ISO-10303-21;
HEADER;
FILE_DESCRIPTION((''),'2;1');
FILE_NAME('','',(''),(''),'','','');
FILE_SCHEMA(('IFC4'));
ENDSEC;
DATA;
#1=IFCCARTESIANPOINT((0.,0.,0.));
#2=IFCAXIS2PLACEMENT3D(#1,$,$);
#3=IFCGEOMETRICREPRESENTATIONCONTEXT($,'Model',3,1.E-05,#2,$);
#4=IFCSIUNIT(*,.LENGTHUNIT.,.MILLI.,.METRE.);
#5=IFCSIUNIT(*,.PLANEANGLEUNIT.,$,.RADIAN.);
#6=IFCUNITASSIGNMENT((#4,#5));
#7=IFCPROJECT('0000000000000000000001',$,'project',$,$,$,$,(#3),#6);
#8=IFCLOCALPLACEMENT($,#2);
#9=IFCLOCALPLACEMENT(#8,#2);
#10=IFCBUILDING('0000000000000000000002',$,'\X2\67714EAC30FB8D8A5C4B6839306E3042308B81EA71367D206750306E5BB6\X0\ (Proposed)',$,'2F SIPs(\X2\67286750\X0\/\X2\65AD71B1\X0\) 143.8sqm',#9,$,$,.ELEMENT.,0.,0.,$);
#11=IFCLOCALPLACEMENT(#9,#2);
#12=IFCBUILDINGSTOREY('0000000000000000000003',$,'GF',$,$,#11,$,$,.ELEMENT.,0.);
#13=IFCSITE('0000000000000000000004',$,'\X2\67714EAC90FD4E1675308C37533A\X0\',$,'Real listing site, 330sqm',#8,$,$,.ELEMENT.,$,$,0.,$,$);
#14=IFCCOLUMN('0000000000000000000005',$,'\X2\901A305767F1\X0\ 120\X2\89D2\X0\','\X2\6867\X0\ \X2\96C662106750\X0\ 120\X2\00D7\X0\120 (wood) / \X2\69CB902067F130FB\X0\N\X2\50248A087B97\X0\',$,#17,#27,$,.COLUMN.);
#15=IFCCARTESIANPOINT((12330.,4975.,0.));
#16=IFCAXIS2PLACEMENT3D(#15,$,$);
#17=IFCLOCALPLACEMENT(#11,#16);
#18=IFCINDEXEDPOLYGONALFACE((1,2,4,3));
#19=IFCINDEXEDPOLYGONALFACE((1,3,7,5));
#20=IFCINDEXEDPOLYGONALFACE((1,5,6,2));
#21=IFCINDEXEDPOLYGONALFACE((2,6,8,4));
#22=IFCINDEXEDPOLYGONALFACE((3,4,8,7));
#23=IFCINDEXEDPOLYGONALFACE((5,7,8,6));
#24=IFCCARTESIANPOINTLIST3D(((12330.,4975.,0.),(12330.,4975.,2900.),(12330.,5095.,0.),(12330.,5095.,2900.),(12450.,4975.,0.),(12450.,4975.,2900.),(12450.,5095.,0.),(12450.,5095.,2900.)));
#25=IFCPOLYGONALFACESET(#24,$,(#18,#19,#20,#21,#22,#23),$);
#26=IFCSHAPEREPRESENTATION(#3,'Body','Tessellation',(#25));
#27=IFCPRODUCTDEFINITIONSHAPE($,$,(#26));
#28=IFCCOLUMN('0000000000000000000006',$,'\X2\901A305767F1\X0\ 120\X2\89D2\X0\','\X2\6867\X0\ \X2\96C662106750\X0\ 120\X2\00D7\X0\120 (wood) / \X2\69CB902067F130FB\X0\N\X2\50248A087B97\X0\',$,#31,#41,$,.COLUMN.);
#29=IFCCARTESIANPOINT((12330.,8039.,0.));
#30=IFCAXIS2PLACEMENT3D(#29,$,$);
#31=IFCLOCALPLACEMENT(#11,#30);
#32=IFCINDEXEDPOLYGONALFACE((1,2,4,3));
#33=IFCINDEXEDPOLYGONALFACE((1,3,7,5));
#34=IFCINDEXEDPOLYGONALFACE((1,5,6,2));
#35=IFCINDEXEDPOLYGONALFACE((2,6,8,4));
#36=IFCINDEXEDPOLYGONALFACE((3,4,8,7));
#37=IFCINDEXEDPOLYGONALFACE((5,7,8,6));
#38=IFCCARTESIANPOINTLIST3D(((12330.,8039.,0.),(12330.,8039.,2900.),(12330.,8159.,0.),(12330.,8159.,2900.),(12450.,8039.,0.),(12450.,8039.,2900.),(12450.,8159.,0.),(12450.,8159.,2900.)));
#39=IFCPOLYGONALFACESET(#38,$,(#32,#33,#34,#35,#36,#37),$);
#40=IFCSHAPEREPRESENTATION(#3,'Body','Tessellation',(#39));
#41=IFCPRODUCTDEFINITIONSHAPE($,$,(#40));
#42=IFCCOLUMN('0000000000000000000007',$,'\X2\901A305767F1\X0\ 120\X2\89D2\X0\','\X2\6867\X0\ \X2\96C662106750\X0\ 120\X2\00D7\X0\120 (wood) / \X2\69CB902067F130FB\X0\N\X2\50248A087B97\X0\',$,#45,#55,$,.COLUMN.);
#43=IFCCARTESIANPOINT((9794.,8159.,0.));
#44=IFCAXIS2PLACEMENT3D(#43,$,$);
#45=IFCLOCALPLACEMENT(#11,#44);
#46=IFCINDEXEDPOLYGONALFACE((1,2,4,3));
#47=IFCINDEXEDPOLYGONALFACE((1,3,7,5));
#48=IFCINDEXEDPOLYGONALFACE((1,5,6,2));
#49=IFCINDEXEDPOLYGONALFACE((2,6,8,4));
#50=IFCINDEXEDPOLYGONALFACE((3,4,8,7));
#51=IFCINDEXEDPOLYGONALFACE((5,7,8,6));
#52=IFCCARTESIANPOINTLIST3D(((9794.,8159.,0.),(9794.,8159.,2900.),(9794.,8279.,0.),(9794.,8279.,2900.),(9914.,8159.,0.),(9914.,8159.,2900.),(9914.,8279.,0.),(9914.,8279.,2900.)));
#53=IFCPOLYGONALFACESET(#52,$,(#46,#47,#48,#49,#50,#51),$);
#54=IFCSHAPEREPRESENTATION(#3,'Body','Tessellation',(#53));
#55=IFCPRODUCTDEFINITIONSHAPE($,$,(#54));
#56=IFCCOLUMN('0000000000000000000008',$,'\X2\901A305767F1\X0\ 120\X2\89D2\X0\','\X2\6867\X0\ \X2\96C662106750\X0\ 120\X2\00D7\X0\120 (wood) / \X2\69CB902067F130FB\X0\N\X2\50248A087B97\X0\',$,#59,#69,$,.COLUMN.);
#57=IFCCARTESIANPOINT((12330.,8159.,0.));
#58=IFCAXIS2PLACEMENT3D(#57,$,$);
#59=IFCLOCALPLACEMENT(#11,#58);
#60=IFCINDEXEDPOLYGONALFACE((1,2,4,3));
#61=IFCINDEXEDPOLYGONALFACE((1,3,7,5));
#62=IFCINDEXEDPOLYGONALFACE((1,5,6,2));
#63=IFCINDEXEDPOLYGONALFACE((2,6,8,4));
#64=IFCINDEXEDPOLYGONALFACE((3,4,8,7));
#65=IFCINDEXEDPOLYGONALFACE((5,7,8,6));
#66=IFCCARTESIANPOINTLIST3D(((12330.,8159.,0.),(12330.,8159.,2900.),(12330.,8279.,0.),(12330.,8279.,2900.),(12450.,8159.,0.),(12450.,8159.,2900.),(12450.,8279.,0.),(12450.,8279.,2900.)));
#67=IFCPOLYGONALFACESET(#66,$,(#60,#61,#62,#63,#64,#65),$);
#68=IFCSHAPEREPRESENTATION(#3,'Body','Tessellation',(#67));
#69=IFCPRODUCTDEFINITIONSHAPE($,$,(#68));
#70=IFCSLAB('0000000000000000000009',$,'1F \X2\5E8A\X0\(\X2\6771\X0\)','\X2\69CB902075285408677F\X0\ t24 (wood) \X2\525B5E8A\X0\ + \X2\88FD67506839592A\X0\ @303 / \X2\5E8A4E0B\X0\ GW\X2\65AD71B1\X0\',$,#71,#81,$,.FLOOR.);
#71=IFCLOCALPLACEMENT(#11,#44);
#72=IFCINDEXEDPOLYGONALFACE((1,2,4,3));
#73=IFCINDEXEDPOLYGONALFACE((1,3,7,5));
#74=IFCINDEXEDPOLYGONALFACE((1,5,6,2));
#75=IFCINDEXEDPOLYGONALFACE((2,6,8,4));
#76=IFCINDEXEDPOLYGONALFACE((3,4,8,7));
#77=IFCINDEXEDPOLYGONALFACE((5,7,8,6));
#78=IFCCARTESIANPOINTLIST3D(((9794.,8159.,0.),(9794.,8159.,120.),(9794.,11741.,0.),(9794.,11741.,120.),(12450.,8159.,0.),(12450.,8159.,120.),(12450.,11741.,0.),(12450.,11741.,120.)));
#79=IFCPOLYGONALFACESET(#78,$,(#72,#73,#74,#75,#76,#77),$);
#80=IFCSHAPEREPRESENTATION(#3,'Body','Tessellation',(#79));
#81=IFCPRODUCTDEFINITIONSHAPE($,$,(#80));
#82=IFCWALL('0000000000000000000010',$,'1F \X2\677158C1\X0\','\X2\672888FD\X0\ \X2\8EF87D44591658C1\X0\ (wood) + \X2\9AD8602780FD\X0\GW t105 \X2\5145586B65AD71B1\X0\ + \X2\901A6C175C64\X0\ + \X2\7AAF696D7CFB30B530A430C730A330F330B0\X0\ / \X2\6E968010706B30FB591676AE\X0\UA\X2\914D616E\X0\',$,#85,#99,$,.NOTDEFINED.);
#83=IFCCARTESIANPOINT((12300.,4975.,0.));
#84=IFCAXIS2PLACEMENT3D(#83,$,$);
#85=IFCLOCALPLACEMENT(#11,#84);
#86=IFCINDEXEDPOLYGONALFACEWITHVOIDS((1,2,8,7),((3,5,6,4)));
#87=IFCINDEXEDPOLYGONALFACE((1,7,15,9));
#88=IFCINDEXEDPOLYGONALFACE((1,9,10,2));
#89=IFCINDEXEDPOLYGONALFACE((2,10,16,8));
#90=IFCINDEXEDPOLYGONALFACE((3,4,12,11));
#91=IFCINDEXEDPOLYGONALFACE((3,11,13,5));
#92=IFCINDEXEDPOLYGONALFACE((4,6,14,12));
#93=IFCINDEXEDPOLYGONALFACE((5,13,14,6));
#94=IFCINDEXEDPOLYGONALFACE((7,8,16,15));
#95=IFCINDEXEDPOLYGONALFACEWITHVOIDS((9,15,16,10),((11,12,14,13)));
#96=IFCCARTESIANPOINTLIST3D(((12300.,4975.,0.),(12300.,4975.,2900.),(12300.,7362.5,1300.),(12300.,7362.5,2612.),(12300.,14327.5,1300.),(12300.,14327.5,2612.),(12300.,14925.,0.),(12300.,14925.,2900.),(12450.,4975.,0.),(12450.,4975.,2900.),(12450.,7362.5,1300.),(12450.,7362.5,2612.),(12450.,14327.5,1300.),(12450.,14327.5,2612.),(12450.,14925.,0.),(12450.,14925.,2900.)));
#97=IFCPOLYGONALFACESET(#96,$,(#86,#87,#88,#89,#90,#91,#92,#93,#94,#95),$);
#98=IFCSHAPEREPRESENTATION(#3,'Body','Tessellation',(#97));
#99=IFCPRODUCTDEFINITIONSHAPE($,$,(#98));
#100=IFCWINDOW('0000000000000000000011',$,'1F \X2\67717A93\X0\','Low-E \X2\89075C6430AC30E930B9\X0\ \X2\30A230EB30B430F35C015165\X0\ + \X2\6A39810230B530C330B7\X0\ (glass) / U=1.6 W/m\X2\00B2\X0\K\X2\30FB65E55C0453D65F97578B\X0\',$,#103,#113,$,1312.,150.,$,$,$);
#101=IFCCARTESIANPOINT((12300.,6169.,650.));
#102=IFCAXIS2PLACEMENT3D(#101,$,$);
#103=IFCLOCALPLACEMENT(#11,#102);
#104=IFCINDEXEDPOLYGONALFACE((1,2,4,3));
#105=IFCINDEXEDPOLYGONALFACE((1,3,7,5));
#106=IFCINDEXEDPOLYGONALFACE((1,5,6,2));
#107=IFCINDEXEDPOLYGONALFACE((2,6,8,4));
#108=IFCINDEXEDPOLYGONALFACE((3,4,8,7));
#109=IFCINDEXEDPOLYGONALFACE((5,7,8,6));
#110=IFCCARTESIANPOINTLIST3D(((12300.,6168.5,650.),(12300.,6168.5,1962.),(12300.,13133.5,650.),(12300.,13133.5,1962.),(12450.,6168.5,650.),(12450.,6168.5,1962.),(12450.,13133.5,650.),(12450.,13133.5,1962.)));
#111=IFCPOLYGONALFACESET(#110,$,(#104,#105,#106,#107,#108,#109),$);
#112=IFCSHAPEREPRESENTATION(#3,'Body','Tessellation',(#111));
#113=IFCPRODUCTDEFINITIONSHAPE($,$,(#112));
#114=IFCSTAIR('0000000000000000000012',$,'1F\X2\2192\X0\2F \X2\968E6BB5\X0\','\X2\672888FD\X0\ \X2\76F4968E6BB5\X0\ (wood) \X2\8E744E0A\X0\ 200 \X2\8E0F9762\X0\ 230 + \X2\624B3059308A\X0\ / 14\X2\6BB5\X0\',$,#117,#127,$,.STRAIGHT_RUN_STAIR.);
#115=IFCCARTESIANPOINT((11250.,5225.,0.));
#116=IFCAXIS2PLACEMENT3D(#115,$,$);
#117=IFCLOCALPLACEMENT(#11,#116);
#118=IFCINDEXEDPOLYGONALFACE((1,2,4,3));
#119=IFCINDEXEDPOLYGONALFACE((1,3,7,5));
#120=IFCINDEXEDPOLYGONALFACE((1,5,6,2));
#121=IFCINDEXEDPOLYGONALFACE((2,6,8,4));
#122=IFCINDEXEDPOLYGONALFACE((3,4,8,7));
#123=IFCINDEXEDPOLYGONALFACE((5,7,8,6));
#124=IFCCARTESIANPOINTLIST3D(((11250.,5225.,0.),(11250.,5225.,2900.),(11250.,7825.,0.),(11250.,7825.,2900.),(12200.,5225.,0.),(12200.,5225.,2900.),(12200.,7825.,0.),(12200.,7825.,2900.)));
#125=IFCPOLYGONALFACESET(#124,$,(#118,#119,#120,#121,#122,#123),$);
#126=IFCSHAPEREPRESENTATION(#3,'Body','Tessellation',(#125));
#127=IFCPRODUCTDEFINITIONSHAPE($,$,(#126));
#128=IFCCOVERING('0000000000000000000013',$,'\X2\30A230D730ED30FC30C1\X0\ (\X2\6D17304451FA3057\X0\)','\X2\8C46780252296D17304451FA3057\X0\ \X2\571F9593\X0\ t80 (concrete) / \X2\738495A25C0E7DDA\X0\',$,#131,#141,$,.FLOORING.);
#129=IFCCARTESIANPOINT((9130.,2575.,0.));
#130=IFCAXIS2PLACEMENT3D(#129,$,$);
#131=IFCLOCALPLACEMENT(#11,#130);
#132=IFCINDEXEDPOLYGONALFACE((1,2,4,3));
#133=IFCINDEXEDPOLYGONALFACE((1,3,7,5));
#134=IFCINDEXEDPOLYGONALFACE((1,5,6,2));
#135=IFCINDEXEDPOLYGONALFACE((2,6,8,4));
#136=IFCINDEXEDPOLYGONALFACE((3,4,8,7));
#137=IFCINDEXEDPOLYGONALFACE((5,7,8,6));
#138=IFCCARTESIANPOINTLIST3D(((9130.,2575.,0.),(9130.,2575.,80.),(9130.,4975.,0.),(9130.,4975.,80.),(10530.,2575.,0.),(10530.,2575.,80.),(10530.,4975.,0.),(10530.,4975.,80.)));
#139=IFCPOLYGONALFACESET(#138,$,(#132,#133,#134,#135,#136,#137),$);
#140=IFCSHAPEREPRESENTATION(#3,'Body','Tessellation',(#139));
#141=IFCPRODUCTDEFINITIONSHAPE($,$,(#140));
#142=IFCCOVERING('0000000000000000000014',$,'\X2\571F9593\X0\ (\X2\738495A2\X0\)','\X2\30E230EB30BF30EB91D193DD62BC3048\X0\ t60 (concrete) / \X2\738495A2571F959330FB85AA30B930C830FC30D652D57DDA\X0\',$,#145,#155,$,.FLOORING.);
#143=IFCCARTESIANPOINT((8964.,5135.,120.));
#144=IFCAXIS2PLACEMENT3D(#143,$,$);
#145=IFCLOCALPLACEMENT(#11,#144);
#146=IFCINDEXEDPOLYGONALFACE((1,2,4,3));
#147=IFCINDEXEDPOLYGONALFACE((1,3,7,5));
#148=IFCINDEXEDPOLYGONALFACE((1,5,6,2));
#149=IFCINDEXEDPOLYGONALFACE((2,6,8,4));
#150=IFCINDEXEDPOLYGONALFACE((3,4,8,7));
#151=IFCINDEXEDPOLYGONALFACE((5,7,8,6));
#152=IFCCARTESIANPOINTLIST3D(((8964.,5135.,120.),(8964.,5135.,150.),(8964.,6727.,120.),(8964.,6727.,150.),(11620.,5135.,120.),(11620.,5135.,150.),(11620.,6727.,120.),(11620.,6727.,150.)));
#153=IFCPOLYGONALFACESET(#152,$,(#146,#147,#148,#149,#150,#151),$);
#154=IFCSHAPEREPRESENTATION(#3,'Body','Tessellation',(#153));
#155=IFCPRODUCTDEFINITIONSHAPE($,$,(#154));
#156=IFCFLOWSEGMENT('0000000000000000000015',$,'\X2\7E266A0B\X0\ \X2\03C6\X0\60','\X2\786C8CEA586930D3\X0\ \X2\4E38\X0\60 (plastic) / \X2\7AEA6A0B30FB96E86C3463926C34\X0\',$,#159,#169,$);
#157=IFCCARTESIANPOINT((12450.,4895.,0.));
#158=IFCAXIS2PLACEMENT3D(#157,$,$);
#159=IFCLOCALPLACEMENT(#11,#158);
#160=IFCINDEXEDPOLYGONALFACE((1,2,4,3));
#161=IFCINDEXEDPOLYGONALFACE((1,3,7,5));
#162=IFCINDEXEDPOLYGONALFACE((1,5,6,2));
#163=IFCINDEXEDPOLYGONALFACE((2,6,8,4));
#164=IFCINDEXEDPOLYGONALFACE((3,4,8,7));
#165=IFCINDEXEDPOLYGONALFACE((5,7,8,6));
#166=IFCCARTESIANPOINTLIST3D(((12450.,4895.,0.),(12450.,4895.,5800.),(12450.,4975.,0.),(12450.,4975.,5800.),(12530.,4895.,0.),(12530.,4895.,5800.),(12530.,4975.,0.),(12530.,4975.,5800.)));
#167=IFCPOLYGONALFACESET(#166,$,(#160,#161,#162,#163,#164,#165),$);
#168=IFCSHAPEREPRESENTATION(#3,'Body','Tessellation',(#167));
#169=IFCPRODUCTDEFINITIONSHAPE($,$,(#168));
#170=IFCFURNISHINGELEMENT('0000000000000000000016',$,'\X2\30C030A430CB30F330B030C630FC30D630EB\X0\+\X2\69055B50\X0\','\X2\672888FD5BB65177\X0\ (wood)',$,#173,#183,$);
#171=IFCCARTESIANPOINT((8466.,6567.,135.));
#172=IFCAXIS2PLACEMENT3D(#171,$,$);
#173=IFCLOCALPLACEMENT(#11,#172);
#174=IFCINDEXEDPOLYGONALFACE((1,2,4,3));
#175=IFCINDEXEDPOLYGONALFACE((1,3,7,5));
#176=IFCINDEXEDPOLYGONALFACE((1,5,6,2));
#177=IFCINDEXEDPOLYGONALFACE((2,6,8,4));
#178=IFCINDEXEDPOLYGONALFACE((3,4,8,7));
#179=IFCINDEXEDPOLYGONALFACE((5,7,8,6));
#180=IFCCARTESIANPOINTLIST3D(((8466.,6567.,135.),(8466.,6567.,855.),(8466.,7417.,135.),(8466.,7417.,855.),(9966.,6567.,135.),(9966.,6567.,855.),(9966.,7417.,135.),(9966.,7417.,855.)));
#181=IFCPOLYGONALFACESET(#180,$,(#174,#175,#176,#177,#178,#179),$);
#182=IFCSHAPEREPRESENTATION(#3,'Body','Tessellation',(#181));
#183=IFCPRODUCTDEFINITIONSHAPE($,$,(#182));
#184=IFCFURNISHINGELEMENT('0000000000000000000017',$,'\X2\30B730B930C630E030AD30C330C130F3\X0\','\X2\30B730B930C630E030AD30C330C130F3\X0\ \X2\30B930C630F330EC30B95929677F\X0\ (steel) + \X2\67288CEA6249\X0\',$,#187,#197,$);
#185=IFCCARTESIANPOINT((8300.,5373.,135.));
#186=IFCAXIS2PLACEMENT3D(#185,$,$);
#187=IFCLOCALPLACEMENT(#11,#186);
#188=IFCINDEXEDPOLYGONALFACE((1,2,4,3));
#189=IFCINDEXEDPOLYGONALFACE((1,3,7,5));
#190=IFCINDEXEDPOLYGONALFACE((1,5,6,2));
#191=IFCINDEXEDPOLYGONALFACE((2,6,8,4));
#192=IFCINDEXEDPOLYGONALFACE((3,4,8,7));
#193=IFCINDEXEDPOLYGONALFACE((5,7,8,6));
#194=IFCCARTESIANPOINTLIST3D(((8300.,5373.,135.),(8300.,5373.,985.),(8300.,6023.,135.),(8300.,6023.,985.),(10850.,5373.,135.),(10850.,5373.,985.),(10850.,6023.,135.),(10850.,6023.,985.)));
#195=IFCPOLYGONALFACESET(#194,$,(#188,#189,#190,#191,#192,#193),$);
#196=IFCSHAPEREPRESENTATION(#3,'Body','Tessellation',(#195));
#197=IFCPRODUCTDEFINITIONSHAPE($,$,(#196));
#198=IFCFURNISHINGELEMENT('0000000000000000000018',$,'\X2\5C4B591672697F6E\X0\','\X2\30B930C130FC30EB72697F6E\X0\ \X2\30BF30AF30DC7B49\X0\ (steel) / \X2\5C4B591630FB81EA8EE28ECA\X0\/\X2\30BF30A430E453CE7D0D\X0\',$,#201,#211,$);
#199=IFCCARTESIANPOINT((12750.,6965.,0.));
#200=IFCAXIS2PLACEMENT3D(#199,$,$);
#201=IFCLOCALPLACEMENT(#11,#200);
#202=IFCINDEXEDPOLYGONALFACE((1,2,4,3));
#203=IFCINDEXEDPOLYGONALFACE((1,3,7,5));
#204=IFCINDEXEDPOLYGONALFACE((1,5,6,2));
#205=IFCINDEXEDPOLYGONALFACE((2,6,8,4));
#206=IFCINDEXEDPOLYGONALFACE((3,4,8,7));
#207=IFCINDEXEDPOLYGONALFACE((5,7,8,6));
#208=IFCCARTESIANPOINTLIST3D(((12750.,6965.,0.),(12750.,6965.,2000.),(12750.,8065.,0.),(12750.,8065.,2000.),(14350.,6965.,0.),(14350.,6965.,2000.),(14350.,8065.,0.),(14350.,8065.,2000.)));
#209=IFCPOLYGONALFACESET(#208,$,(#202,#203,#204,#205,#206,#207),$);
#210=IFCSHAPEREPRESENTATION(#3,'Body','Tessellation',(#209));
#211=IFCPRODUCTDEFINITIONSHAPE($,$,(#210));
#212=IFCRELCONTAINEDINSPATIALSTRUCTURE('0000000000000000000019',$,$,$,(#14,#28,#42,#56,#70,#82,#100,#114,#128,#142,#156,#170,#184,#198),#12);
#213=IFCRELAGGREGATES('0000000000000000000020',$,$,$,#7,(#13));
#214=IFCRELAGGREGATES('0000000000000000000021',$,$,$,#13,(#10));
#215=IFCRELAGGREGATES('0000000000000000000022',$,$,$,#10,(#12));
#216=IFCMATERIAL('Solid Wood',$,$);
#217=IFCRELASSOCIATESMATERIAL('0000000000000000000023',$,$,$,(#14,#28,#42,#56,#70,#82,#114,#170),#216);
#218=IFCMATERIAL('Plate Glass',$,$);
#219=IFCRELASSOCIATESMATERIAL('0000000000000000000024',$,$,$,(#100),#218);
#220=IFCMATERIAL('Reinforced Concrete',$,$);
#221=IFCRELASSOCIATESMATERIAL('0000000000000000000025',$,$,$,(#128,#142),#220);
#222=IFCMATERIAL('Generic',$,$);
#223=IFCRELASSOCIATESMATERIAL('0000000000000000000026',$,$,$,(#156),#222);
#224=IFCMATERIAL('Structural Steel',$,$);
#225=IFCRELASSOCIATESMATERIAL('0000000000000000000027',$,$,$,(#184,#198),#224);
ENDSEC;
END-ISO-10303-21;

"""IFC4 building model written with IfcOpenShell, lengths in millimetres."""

from ifc_helpers import new_model, si_unit, frame, frame_2d, origin, place, context, project, spatial, rectangle, extrude, material, element, fill, save


model = new_model("IFC4")

# Units and contexts
model_context = context("Model", 3, precision=1e-05, world=origin())
ifc_project = project(units=[si_unit("LENGTHUNIT", "METRE", prefix="MILLI"), si_unit("PLANEANGLEUNIT", "RADIAN")], contexts=[model_context])

# Site, building, storey
site_placement = place(None, origin())
site = spatial("IfcSite", under=ifc_project, at=site_placement, Name="東京都世田谷区", ObjectType="Real listing site, 330sqm", CompositionType="ELEMENT", RefElevation=0.0)
building_placement = place(site_placement, origin())
building = spatial("IfcBuilding", under=site, at=building_placement, Name="東京・越屋根のある自然素材の家 (Proposed)", ObjectType="2F SIPs(木材/断熱) 143.8sqm", CompositionType="ELEMENT", ElevationOfRefHeight=0.0, ElevationOfTerrain=0.0)
storey_placement = place(building_placement, origin())
storey = spatial("IfcBuildingStorey", under=building, at=storey_placement, Name="GF", CompositionType="ELEMENT", Elevation=0.0)

# Columns
ifc_material_1 = material(Name="Solid Wood")
column_1_placement = place(storey_placement, frame((12330.0, 4975.0, 0.0)))
element("IfcColumn", 1, at=column_1_placement, inside=storey, material=ifc_material_1, Name="通し柱 120角", Description="桧 集成材 120×120 (wood) / 構造柱・N値計算", PredefinedType="COLUMN", context=model_context, shape_type="SweptSolid", body=[
    extrude(rectangle(XDim=120.0, YDim=120.0, at=frame_2d((60.0, 60.0))), frame((12330.0, 4975.0, 0.0)), (0.0, 0.0, 1.0), 2900.0),
])
column_2_placement = place(storey_placement, frame((12330.0, 8039.0, 0.0)))
element("IfcColumn", 2, at=column_2_placement, inside=storey, material=ifc_material_1, Name="通し柱 120角", Description="桧 集成材 120×120 (wood) / 構造柱・N値計算", PredefinedType="COLUMN", context=model_context, shape_type="SweptSolid", body=[
    extrude(rectangle(XDim=120.0, YDim=120.0, at=frame_2d((60.0, 60.0))), frame((12330.0, 8039.0, 0.0)), (0.0, 0.0, 1.0), 2900.0),
])
column_3_placement = place(storey_placement, frame((9794.0, 8159.0, 0.0)))
element("IfcColumn", 3, at=column_3_placement, inside=storey, material=ifc_material_1, Name="通し柱 120角", Description="桧 集成材 120×120 (wood) / 構造柱・N値計算", PredefinedType="COLUMN", context=model_context, shape_type="SweptSolid", body=[
    extrude(rectangle(XDim=120.0, YDim=120.0, at=frame_2d((60.0, 60.0))), frame((9794.0, 8159.0, 0.0)), (0.0, 0.0, 1.0), 2900.0),
])
column_4_placement = place(storey_placement, frame((12330.0, 8159.0, 0.0)))
element("IfcColumn", 4, at=column_4_placement, inside=storey, material=ifc_material_1, Name="通し柱 120角", Description="桧 集成材 120×120 (wood) / 構造柱・N値計算", PredefinedType="COLUMN", context=model_context, shape_type="SweptSolid", body=[
    extrude(rectangle(XDim=120.0, YDim=120.0, at=frame_2d((60.0, 60.0))), frame((12330.0, 8159.0, 0.0)), (0.0, 0.0, 1.0), 2900.0),
])

# Slab
slab_placement = place(storey_placement, frame((9794.0, 8159.0, 0.0)))
element("IfcSlab", 5, at=slab_placement, inside=storey, material=ifc_material_1, Name="1F 床(東)", Description="構造用合板 t24 (wood) 剛床 + 製材根太 @303 / 床下 GW断熱", PredefinedType="FLOOR", context=model_context, shape_type="SweptSolid", body=[
    extrude(rectangle(XDim=2656.0, YDim=3582.0, at=frame_2d((1328.0, 1791.0))), frame((9794.0, 8159.0, 0.0)), (0.0, 0.0, 1.0), 120.0),
])

# Wall, opening, window
wall_1_placement = place(storey_placement, frame((12300.0, 4975.0, 0.0)))
wall_1 = element("IfcWall", 6, at=wall_1_placement, inside=storey, material=ifc_material_1, Name="1F 東壁", Description="木製 軸組外壁 (wood) + 高性能GW t105 充填断熱 + 通気層 + 窯業系サイディング / 準耐火・外皮UA配慮", PredefinedType="NOTDEFINED", context=model_context, shape_type="SweptSolid", body=[
    extrude(rectangle(XDim=150.0, YDim=9950.0, at=frame_2d((75.0, 4975.0))), frame((12300.0, 4975.0, 0.0)), (0.0, 0.0, 1.0), 2900.0),
])
opening_placement = place(storey_placement, frame((12300.0, 6169.0, 650.0)))
opening = element("IfcOpeningElement", 7, at=opening_placement, cuts=wall_1, PredefinedType="NOTDEFINED", context=model_context, shape_type="SweptSolid", body=[
    extrude(rectangle(XDim=150.0, YDim=6965.0, at=frame_2d((75.0, 3482.0))), frame((12300.0, 6169.0, 650.0)), (0.0, 0.0, 1.0), 1312.0),
])
ifc_material_2 = material(Name="Plate Glass")
window_placement = place(storey_placement, frame((12300.0, 6169.0, 650.0)))
window = element("IfcWindow", 8, at=window_placement, inside=storey, material=ifc_material_2, Name="1F 東窓", Description="Low-E 複層ガラス アルゴン封入 + 樹脂サッシ (glass) / U=1.6 W/m²K・日射取得型", OverallHeight=1312.0, OverallWidth=150.0, context=model_context, shape_type="SweptSolid", body=[
    extrude(rectangle(XDim=150.0, YDim=6965.0, at=frame_2d((75.0, 3482.0))), frame((12300.0, 6169.0, 650.0)), (0.0, 0.0, 1.0), 1312.0),
])
fill(opening, window)

# Stair
stair_placement = place(storey_placement, frame((11250.0, 5225.0, 0.0)))
element("IfcStair", 9, at=stair_placement, inside=storey, material=ifc_material_1, Name="1F→2F 階段", Description="木製 直階段 (wood) 蹴上 200 踏面 230 + 手すり / 14段", PredefinedType="STRAIGHT_RUN_STAIR", context=model_context, shape_type="SweptSolid", body=[
    extrude(rectangle(XDim=950.0, YDim=2600.0, at=frame_2d((475.0, 1300.0))), frame((11250.0, 5225.0, 0.0)), (0.0, 0.0, 1.0), 2900.0),
])

# Coverings
ifc_material_3 = material(Name="Reinforced Concrete")
covering_1_placement = place(storey_placement, frame((9130.0, 2575.0, 0.0)))
element("IfcCovering", 10, at=covering_1_placement, inside=storey, material=ifc_material_3, Name="アプローチ (洗い出し)", Description="豆砂利洗い出し 土間 t80 (concrete) / 玄関導線", PredefinedType="FLOORING", context=model_context, shape_type="SweptSolid", body=[
    extrude(rectangle(XDim=1400.0, YDim=2400.0, at=frame_2d((700.0, 1200.0))), frame((9130.0, 2575.0, 0.0)), (0.0, 0.0, 1.0), 80.0),
])
covering_2_placement = place(storey_placement, frame((8964.0, 5135.0, 120.0)))
element("IfcCovering", 11, at=covering_2_placement, inside=storey, material=ifc_material_3, Name="土間 (玄関)", Description="モルタル金鏝押え t60 (concrete) / 玄関土間・薪ストーブ動線", PredefinedType="FLOORING", context=model_context, shape_type="SweptSolid", body=[
    extrude(rectangle(XDim=2656.0, YDim=1592.0, at=frame_2d((1328.0, 796.0))), frame((8964.0, 5135.0, 120.0)), (0.0, 0.0, 1.0), 30.0),
])

# Flow segment
ifc_material_4 = material(Name="Generic")
flow_segment_placement = place(storey_placement, frame((12450.0, 4895.0, 0.0)))
element("IfcFlowSegment", 12, at=flow_segment_placement, inside=storey, material=ifc_material_4, Name="縦樋 φ60", Description="硬質塩ビ 丸60 (plastic) / 竪樋・雨水排水", context=model_context, shape_type="SweptSolid", body=[
    extrude(rectangle(XDim=80.0, YDim=80.0, at=frame_2d((40.0, 40.0))), frame((12450.0, 4895.0, 0.0)), (0.0, 0.0, 1.0), 5800.0),
])

# Furnishing elements
furnishing_1_placement = place(storey_placement, frame((8466.0, 6567.0, 135.0)))
element("IfcFurnishingElement", 13, at=furnishing_1_placement, inside=storey, material=ifc_material_1, Name="ダイニングテーブル+椅子", Description="木製家具 (wood)", context=model_context, shape_type="SweptSolid", body=[
    extrude(rectangle(XDim=1500.0, YDim=850.0, at=frame_2d((750.0, 425.0))), frame((8466.0, 6567.0, 135.0)), (0.0, 0.0, 1.0), 720.0),
])
ifc_material_5 = material(Name="Structural Steel")
furnishing_2_placement = place(storey_placement, frame((8300.0, 5373.0, 135.0)))
element("IfcFurnishingElement", 14, at=furnishing_2_placement, inside=storey, material=ifc_material_5, Name="システムキッチン", Description="システムキッチン ステンレス天板 (steel) + 木質扉", context=model_context, shape_type="SweptSolid", body=[
    extrude(rectangle(XDim=2550.0, YDim=650.0, at=frame_2d((1275.0, 325.0))), frame((8300.0, 5373.0, 135.0)), (0.0, 0.0, 1.0), 850.0),
])
furnishing_3_placement = place(storey_placement, frame((12750.0, 6965.0, 0.0)))
element("IfcFurnishingElement", 15, at=furnishing_3_placement, inside=storey, material=ifc_material_5, Name="屋外物置", Description="スチール物置 タクボ等 (steel) / 屋外・自転車/タイヤ収納", context=model_context, shape_type="SweptSolid", body=[
    extrude(rectangle(XDim=1600.0, YDim=1100.0, at=frame_2d((800.0, 550.0))), frame((12750.0, 6965.0, 0.0)), (0.0, 0.0, 1.0), 2000.0),
])

save(model, "model.ifc")
